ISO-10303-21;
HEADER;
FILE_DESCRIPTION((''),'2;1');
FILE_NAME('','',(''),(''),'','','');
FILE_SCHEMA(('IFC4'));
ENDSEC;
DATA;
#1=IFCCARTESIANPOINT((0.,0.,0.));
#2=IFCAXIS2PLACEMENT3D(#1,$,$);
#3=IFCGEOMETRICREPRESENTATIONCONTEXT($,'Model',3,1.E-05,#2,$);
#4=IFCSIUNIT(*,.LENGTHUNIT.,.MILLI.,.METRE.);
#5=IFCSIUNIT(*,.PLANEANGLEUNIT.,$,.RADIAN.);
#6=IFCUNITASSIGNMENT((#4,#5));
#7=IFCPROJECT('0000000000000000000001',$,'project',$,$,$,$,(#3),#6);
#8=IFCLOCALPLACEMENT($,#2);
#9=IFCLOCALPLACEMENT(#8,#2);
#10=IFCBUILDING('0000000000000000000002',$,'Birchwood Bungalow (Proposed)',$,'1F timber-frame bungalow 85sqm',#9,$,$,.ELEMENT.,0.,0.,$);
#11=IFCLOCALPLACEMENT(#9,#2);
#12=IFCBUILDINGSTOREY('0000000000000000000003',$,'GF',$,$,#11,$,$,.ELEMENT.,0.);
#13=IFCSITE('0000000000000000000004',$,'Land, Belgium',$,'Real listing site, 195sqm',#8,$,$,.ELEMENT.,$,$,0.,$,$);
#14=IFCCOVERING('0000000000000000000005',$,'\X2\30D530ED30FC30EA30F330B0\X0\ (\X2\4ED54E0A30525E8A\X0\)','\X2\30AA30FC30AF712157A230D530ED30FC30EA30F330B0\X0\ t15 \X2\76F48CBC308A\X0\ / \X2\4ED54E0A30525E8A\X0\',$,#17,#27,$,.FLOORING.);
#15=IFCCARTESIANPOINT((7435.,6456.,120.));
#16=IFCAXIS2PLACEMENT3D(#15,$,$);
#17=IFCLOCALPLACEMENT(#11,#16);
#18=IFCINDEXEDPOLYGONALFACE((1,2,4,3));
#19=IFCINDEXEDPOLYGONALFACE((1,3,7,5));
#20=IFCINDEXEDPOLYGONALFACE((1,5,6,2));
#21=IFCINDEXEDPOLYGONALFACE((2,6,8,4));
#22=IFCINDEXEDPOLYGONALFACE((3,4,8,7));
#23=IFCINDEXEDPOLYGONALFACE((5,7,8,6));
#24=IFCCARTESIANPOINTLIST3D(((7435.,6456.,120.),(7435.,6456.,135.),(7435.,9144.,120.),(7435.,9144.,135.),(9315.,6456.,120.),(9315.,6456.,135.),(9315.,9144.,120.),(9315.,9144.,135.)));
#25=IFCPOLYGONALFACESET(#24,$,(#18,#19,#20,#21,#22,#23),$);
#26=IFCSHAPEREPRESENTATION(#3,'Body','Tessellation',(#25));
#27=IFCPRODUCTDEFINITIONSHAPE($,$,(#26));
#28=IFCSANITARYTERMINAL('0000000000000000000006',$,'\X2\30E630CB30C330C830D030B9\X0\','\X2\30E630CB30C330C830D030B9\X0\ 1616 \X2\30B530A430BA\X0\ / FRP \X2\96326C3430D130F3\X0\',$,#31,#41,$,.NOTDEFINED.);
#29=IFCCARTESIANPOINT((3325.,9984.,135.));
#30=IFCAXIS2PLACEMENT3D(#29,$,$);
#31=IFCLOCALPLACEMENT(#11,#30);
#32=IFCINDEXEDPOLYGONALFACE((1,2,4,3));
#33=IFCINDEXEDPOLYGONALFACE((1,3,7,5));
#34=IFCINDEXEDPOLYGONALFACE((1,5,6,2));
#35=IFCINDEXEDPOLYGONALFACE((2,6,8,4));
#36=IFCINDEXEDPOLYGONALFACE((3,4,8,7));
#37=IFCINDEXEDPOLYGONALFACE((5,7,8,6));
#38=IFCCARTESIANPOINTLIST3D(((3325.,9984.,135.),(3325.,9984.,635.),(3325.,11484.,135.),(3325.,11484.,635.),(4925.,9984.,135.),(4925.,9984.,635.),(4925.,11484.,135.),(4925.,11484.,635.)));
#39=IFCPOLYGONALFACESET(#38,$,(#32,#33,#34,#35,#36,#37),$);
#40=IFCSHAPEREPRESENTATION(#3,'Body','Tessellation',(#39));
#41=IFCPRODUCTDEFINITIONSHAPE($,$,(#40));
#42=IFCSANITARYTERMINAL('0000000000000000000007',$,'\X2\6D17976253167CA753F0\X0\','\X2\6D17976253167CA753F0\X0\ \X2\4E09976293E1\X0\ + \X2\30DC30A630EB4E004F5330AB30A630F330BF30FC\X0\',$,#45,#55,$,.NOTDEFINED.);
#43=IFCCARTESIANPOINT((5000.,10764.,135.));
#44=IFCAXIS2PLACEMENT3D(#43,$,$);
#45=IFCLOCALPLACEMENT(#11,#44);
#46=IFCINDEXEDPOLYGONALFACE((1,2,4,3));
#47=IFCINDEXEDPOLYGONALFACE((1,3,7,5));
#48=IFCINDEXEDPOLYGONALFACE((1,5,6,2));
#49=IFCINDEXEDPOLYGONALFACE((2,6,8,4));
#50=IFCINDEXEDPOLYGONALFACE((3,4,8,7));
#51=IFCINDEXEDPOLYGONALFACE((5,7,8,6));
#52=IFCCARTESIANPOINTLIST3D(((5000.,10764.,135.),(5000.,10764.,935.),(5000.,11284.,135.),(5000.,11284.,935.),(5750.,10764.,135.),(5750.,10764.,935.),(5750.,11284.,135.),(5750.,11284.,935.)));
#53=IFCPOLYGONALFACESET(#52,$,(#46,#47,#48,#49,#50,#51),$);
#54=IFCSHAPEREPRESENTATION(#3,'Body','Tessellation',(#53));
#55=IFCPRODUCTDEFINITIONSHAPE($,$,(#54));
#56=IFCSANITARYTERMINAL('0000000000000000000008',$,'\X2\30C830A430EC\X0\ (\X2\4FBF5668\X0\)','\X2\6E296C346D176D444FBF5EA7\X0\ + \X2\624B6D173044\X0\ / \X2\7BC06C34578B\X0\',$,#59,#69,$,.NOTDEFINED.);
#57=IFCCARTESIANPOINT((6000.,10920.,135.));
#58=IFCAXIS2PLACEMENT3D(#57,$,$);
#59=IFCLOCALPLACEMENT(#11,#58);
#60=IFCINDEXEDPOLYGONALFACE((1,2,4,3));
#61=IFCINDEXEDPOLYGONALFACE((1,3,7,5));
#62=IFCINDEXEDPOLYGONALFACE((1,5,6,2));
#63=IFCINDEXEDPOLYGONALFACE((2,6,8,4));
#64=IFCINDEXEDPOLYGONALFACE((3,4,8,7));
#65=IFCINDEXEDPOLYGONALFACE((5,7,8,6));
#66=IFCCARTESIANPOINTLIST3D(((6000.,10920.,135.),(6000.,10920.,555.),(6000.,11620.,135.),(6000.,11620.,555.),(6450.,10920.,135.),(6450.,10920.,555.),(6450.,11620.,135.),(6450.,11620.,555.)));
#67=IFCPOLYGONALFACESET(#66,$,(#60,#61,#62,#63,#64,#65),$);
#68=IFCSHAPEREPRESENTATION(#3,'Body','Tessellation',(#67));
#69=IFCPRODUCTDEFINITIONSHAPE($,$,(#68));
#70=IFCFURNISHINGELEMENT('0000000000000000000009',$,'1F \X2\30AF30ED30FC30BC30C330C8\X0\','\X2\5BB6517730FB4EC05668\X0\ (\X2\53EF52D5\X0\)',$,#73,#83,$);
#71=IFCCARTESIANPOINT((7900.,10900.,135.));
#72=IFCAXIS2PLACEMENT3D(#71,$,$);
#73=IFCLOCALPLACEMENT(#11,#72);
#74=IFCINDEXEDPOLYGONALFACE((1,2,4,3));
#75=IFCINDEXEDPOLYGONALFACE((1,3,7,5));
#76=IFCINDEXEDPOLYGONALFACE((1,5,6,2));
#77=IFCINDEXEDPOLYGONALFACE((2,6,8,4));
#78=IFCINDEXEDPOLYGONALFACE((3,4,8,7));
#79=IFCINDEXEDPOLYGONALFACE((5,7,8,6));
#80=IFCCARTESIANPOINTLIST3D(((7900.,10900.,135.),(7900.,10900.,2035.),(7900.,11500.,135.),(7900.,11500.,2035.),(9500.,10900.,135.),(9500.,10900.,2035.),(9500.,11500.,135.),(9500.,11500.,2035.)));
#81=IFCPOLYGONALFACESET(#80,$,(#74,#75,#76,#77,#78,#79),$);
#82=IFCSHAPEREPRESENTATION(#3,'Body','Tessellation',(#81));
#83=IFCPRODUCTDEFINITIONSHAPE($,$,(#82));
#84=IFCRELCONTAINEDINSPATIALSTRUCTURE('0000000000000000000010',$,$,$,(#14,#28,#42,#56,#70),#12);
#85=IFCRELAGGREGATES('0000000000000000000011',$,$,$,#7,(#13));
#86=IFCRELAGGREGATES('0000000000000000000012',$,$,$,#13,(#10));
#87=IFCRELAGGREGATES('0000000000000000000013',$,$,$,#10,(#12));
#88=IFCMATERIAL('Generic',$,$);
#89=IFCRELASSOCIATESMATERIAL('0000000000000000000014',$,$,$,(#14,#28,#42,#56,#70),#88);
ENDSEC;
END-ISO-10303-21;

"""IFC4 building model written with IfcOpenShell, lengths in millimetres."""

from ifc_helpers import new_model, si_unit, frame, frame_2d, origin, place, context, project, spatial, rectangle, extrude, material, element, save


model = new_model("IFC4")

# Units and contexts
model_context = context("Model", 3, precision=1e-05, world=origin())
ifc_project = project(units=[si_unit("LENGTHUNIT", "METRE", prefix="MILLI"), si_unit("PLANEANGLEUNIT", "RADIAN")], contexts=[model_context])

# Site, building, storey
site_placement = place(None, origin())
site = spatial("IfcSite", under=ifc_project, at=site_placement, Name="Land, Belgium", ObjectType="Real listing site, 195sqm", CompositionType="ELEMENT", RefElevation=0.0)
building_placement = place(site_placement, origin())
building = spatial("IfcBuilding", under=site, at=building_placement, Name="Birchwood Bungalow (Proposed)", ObjectType="1F timber-frame bungalow 85sqm", CompositionType="ELEMENT", ElevationOfRefHeight=0.0, ElevationOfTerrain=0.0)
storey_placement = place(building_placement, origin())
storey = spatial("IfcBuildingStorey", under=building, at=storey_placement, Name="GF", CompositionType="ELEMENT", Elevation=0.0)

# Covering
ifc_material_1 = material(Name="Generic")
covering_1_placement = place(storey_placement, frame((7435.0, 6456.0, 120.0)))
element("IfcCovering", 1, at=covering_1_placement, inside=storey, material=ifc_material_1, Name="フローリング (仕上げ床)", Description="オーク無垢フローリング t15 直貼り / 仕上げ床", PredefinedType="FLOORING", context=model_context, shape_type="SweptSolid", body=[
    extrude(rectangle(XDim=1880.0, YDim=2688.0, at=frame_2d((940.0, 1344.0))), frame((7435.0, 6456.0, 120.0)), (0.0, 0.0, 1.0), 15.0),
])

# Sanitary terminals
sanitary_terminal_1_placement = place(storey_placement, frame((3325.0, 9984.0, 135.0)))
element("IfcSanitaryTerminal", 2, at=sanitary_terminal_1_placement, inside=storey, material=ifc_material_1, Name="ユニットバス", Description="ユニットバス 1616 サイズ / FRP 防水パン", PredefinedType="NOTDEFINED", context=model_context, shape_type="SweptSolid", body=[
    extrude(rectangle(XDim=1600.0, YDim=1500.0, at=frame_2d((800.0, 750.0))), frame((3325.0, 9984.0, 135.0)), (0.0, 0.0, 1.0), 500.0),
])
sanitary_terminal_2_placement = place(storey_placement, frame((5000.0, 10764.0, 135.0)))
element("IfcSanitaryTerminal", 3, at=sanitary_terminal_2_placement, inside=storey, material=ifc_material_1, Name="洗面化粧台", Description="洗面化粧台 三面鏡 + ボウル一体カウンター", PredefinedType="NOTDEFINED", context=model_context, shape_type="SweptSolid", body=[
    extrude(rectangle(XDim=750.0, YDim=520.0, at=frame_2d((375.0, 260.0))), frame((5000.0, 10764.0, 135.0)), (0.0, 0.0, 1.0), 800.0),
])
sanitary_terminal_3_placement = place(storey_placement, frame((6000.0, 10920.0, 135.0)))
element("IfcSanitaryTerminal", 4, at=sanitary_terminal_3_placement, inside=storey, material=ifc_material_1, Name="トイレ (便器)", Description="温水洗浄便座 + 手洗い / 節水型", PredefinedType="NOTDEFINED", context=model_context, shape_type="SweptSolid", body=[
    extrude(rectangle(XDim=450.0, YDim=700.0, at=frame_2d((225.0, 350.0))), frame((6000.0, 10920.0, 135.0)), (0.0, 0.0, 1.0), 420.0),
])

# Furnishing element
furnishing_placement = place(storey_placement, frame((7900.0, 10900.0, 135.0)))
element("IfcFurnishingElement", 5, at=furnishing_placement, inside=storey, material=ifc_material_1, Name="1F クローゼット", Description="家具・什器 (可動)", context=model_context, shape_type="SweptSolid", body=[
    extrude(rectangle(XDim=1600.0, YDim=600.0, at=frame_2d((800.0, 300.0))), frame((7900.0, 10900.0, 135.0)), (0.0, 0.0, 1.0), 1900.0),
])

save(model, "model.ifc")
